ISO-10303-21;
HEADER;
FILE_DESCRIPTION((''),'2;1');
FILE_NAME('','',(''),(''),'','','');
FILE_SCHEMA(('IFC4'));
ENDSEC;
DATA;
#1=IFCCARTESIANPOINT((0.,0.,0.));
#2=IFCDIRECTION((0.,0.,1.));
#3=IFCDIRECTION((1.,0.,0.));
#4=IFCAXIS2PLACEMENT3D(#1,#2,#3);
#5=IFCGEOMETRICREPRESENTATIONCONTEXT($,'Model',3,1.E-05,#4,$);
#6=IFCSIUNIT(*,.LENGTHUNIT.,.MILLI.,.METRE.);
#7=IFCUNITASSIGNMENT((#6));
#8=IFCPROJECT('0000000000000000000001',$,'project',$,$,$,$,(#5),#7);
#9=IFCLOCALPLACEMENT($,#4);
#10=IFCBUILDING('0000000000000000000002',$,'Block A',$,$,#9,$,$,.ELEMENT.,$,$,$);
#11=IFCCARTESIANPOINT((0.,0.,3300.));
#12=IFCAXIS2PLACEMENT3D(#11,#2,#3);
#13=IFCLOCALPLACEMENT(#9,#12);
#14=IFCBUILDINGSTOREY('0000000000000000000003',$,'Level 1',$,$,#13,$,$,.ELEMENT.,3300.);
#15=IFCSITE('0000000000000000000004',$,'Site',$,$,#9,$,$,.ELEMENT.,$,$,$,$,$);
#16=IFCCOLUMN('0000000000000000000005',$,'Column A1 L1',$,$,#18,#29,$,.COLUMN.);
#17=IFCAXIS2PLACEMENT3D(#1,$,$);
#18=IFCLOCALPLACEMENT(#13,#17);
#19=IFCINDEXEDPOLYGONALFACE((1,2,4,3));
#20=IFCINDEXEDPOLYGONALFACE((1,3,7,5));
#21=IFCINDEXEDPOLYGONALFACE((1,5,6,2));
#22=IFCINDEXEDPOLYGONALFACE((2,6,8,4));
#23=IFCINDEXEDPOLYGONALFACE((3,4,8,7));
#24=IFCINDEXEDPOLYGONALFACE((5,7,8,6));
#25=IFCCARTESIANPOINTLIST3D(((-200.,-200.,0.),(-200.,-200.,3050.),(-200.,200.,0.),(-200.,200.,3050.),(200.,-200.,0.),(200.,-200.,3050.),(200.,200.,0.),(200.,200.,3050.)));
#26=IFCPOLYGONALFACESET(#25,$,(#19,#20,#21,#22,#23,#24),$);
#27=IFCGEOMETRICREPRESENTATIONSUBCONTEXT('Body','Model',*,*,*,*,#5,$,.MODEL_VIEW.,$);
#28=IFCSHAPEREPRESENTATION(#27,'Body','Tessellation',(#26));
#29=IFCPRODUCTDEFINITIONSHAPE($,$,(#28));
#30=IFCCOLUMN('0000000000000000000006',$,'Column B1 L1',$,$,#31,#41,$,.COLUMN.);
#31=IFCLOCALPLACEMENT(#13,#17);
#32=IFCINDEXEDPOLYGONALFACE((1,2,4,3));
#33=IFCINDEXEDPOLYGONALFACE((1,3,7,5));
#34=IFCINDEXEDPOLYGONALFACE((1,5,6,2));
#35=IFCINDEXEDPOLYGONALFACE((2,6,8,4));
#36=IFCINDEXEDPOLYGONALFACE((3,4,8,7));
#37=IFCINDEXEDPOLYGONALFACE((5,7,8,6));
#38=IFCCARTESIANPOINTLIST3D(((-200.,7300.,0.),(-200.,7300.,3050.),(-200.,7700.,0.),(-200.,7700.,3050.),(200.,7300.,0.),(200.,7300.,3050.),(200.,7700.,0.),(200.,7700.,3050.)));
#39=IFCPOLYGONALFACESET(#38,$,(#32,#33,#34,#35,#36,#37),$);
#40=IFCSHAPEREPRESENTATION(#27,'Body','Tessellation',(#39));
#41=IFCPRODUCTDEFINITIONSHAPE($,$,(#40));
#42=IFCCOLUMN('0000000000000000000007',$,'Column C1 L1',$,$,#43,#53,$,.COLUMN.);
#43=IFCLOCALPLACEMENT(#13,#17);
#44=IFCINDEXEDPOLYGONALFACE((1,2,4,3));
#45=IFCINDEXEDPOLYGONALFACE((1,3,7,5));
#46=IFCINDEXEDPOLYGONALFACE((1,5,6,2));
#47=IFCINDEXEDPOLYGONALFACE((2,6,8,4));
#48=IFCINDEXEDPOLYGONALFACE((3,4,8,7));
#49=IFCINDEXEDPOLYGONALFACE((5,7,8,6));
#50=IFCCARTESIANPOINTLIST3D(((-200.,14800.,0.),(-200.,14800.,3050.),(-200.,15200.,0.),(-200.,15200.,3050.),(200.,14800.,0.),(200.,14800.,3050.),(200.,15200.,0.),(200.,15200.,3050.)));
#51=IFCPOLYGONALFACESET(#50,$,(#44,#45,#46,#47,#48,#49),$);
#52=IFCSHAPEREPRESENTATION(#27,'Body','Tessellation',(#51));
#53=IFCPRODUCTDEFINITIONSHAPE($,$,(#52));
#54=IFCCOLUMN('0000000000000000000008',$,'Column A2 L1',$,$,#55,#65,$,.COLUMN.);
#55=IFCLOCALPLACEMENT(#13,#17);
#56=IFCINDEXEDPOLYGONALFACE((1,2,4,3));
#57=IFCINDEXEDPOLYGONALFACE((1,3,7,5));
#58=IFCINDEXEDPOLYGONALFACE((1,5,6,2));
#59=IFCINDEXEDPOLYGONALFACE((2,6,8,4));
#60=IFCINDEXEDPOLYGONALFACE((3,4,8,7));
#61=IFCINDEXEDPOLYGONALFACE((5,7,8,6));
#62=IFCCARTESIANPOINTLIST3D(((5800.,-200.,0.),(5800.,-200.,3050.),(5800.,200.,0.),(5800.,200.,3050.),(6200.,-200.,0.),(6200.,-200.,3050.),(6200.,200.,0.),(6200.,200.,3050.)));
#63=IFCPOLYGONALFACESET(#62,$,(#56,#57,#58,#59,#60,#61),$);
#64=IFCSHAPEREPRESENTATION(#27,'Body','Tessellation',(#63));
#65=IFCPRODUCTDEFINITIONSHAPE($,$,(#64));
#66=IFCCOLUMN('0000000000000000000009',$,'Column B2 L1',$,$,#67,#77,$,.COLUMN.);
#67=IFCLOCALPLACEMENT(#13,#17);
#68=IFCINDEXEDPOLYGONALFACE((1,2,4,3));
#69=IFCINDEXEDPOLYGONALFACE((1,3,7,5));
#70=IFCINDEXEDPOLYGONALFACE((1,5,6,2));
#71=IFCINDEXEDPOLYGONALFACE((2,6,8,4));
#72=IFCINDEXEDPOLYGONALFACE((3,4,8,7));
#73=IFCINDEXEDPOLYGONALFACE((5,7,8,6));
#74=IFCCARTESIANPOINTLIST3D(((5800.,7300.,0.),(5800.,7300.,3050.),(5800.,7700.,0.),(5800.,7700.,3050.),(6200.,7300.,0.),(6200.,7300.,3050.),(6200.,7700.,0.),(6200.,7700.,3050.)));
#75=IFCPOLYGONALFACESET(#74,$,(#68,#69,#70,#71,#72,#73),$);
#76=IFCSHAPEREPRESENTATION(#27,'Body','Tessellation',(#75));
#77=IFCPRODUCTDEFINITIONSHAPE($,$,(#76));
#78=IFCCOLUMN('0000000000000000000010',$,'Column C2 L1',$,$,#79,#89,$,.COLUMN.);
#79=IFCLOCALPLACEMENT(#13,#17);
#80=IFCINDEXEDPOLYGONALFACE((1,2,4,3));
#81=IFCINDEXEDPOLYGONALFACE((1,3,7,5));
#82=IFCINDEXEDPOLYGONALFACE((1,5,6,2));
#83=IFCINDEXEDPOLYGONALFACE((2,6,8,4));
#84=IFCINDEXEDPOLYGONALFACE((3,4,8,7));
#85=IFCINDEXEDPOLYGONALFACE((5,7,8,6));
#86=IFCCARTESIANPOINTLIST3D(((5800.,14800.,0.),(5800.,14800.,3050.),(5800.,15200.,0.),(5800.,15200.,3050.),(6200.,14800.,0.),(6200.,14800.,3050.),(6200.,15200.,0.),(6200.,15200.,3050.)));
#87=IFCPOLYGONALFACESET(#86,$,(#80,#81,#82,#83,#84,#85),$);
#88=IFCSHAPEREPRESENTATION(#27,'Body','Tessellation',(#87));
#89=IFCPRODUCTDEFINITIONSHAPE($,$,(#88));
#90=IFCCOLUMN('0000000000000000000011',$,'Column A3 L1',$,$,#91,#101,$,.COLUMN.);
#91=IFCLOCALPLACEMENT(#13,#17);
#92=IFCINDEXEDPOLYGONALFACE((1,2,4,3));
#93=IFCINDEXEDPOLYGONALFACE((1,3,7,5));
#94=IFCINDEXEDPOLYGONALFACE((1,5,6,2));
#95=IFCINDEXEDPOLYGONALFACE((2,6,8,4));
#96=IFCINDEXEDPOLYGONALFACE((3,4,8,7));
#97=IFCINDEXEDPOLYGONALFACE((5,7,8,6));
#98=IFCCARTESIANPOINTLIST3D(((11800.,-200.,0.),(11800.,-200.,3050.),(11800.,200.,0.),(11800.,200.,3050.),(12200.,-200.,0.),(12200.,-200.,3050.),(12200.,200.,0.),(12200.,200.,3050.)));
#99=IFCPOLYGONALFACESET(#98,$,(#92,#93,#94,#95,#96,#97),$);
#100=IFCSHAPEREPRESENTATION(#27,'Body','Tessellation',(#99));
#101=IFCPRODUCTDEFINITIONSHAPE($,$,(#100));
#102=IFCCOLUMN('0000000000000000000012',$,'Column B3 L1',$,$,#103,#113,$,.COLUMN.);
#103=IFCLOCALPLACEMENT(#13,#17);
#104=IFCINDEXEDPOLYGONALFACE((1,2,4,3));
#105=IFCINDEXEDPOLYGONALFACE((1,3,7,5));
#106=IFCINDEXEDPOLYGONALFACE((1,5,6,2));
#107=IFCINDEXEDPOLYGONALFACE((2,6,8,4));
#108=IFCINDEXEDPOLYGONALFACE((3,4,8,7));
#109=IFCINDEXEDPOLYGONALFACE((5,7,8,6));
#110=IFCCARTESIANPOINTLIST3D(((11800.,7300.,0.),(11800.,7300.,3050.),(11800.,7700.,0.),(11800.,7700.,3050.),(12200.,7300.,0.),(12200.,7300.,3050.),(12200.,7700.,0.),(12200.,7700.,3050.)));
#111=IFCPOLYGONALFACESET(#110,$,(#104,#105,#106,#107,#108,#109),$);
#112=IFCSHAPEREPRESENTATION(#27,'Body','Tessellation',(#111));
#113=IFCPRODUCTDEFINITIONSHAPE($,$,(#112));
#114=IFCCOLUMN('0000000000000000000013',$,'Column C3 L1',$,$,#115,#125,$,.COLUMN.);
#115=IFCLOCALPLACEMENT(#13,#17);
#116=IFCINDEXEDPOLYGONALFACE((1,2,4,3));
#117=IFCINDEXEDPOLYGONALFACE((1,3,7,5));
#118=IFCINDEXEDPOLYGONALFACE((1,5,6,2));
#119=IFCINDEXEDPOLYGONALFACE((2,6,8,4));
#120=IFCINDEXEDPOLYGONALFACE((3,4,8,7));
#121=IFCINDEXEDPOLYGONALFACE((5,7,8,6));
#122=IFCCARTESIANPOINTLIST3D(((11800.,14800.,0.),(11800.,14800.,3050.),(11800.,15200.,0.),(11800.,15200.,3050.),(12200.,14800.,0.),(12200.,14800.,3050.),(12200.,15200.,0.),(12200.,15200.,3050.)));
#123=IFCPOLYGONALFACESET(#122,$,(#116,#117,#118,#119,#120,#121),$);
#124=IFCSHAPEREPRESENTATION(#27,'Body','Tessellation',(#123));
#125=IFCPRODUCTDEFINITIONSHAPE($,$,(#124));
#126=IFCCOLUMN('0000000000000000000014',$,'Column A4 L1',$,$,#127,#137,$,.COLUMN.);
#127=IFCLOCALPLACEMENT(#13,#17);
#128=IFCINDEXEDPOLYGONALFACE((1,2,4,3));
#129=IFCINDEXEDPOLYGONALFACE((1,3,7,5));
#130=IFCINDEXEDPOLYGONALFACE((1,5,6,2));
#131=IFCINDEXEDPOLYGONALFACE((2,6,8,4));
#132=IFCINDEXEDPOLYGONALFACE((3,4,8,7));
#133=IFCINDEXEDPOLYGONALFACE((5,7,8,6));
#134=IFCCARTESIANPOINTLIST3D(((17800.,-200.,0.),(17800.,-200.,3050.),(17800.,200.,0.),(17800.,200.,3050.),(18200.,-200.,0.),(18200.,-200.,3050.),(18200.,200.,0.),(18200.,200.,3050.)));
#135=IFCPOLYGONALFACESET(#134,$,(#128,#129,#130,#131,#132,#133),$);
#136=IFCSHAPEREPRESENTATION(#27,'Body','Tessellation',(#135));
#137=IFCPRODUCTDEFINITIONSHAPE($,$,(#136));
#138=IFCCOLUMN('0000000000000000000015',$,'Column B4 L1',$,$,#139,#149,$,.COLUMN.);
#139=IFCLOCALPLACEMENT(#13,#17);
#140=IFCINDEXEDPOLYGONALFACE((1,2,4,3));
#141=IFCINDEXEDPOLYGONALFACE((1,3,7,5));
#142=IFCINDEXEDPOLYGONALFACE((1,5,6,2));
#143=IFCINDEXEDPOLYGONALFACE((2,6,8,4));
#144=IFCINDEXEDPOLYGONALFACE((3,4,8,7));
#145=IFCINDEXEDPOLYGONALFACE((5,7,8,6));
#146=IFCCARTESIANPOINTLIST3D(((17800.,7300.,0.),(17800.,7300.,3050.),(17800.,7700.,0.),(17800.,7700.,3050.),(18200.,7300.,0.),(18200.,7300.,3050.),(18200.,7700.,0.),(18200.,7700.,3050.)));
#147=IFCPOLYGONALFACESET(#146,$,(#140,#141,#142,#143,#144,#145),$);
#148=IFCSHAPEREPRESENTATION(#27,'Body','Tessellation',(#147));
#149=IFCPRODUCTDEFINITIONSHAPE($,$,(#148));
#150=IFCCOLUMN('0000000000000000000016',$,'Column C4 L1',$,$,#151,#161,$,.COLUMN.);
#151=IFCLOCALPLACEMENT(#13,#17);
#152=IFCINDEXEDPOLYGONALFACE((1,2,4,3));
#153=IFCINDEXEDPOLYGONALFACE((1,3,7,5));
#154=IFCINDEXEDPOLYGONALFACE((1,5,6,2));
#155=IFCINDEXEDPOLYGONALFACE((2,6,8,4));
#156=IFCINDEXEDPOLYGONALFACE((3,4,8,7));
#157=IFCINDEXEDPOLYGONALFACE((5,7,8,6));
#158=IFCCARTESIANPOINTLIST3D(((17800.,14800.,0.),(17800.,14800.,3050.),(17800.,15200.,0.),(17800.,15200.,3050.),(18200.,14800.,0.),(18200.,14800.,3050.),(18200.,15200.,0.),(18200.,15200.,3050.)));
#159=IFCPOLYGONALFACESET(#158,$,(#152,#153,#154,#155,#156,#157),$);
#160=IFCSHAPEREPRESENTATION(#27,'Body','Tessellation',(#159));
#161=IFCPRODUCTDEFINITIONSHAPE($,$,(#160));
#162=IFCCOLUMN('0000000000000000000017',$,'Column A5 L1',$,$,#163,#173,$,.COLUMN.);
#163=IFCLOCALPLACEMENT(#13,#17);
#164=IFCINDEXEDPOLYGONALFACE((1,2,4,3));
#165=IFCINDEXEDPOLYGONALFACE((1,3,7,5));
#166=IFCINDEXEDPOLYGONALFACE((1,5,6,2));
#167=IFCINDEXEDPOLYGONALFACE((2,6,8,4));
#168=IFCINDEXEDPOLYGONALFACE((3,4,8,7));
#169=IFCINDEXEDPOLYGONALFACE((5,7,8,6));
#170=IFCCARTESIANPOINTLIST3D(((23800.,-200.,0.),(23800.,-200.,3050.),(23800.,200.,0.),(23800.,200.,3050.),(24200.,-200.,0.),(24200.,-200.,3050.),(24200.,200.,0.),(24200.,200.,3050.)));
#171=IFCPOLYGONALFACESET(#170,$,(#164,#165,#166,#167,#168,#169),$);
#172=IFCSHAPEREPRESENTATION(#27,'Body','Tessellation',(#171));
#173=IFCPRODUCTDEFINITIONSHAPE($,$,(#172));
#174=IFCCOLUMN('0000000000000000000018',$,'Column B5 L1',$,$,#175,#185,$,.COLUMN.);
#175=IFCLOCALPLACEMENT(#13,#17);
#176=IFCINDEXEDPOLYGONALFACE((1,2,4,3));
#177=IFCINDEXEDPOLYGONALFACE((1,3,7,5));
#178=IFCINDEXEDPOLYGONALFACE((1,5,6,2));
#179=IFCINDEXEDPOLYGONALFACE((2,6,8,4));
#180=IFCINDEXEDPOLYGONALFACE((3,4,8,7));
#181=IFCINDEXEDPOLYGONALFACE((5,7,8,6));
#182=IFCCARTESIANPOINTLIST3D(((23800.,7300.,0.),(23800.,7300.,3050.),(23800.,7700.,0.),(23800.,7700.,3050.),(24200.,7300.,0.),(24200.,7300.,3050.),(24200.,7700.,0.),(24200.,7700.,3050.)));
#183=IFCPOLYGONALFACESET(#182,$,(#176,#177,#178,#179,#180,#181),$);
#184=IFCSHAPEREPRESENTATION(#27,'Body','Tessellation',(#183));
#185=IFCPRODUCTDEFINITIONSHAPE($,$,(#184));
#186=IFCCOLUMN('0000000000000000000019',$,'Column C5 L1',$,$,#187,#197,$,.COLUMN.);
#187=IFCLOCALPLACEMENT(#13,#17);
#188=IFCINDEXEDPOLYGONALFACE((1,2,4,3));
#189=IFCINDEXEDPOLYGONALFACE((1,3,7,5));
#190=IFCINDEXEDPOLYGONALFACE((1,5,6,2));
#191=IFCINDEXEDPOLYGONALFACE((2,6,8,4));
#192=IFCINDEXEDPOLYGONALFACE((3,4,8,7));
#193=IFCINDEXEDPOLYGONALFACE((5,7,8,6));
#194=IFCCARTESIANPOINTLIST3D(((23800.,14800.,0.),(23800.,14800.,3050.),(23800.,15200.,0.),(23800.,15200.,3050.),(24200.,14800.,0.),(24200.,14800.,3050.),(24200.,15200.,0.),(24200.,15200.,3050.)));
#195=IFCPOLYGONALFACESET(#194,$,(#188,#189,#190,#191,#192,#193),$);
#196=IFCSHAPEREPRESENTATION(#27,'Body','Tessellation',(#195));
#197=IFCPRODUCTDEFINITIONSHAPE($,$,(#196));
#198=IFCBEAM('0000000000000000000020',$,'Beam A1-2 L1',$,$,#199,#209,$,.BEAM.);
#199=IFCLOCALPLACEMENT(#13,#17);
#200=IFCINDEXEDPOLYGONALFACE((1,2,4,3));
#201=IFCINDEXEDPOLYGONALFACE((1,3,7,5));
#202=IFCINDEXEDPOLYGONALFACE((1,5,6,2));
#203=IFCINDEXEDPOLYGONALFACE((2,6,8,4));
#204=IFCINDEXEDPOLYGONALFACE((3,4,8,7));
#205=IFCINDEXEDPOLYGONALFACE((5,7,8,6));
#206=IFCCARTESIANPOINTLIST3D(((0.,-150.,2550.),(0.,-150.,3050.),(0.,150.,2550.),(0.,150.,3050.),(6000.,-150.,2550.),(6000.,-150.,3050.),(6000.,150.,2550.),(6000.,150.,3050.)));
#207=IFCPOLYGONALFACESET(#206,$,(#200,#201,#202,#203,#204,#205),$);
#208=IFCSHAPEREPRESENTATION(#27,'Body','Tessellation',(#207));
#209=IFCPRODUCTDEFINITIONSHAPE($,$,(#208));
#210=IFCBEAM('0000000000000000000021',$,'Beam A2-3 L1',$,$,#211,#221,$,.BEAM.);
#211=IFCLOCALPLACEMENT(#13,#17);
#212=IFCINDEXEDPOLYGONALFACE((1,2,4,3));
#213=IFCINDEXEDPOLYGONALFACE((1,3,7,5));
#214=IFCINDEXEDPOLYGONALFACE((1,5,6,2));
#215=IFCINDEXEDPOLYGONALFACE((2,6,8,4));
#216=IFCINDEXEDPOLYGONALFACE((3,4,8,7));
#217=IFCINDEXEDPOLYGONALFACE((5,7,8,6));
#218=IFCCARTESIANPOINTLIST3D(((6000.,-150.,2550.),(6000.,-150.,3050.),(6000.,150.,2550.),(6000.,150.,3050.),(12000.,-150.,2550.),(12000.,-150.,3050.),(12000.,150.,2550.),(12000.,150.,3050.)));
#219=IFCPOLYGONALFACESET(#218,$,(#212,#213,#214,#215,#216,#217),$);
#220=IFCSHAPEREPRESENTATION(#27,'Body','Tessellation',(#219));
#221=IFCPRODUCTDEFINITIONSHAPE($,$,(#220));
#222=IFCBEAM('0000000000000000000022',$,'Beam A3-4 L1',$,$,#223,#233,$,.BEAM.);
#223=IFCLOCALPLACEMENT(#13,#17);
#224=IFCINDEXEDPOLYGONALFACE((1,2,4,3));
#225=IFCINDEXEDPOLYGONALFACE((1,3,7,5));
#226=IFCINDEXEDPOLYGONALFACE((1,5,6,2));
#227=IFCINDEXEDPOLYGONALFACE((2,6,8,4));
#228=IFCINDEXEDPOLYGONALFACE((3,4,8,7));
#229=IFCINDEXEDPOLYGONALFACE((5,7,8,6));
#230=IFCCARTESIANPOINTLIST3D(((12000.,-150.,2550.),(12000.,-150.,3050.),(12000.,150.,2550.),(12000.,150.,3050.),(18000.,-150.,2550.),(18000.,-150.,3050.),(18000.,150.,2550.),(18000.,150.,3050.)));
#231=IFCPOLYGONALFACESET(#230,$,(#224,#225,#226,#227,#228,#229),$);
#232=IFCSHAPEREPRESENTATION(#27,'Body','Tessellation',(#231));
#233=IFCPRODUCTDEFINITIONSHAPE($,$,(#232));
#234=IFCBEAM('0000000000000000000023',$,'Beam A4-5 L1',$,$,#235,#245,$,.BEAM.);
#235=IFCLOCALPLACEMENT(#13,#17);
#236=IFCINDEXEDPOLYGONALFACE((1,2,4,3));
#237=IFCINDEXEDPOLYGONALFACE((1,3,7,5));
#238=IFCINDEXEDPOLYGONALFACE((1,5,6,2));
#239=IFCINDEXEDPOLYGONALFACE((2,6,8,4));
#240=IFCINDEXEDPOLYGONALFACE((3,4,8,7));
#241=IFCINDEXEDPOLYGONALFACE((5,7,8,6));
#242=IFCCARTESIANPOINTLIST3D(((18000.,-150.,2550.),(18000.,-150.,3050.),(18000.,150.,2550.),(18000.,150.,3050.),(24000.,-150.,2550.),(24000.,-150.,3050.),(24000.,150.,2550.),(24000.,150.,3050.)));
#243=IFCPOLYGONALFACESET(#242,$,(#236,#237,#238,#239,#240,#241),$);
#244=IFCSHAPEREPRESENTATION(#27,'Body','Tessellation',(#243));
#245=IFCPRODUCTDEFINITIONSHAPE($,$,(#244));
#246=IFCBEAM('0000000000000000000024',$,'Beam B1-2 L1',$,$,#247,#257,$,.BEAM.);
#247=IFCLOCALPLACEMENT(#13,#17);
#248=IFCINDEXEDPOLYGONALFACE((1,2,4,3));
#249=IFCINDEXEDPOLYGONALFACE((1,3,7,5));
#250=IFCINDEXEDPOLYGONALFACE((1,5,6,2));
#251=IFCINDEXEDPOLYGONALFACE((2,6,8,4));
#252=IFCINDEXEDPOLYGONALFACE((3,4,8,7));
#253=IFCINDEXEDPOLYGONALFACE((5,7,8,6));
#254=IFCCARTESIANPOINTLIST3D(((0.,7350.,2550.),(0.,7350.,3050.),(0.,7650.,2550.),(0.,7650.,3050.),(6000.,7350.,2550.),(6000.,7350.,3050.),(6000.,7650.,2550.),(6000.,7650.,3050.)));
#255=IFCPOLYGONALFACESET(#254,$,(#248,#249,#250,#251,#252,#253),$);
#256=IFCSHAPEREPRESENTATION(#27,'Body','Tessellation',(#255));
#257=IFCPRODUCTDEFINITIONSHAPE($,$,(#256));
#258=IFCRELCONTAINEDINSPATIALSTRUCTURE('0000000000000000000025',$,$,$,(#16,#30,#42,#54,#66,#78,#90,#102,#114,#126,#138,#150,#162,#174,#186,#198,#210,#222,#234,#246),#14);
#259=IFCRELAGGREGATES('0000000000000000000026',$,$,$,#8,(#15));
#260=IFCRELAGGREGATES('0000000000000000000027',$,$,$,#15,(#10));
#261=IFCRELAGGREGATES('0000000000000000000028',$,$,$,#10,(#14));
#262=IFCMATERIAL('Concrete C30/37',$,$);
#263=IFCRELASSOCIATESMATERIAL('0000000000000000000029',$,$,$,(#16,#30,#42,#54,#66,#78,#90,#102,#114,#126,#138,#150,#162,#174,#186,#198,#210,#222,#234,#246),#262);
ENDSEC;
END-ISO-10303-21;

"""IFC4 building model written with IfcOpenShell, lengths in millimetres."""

from ifc_helpers import new_model, si_unit, frame, frame_2d, origin_with_axes, origin_2d, place, context, subcontext, project, spatial, rectangle, extrude, material, element, save


model = new_model("IFC4")

# Units and contexts
model_context = context("Model", 3, precision=1e-05, world=origin_with_axes())
body_context = subcontext(model_context, "Body", "Model", "MODEL_VIEW")
ifc_project = project(units=[si_unit("LENGTHUNIT", "METRE", prefix="MILLI")], contexts=[model_context])

# Site, building, storey
placement = place(None, origin_with_axes())
site = spatial("IfcSite", under=ifc_project, at=placement, Name="Site", CompositionType="ELEMENT")
building = spatial("IfcBuilding", under=site, at=placement, Name="Block A", CompositionType="ELEMENT")
storey_placement = place(placement, frame((0.0, 0.0, 3300.0), z_axis=(0.0, 0.0, 1.0), x_axis=(1.0, 0.0, 0.0)))
storey = spatial("IfcBuildingStorey", under=building, at=storey_placement, Name="Level 1", CompositionType="ELEMENT", Elevation=3300.0)

# Columns
ifc_material_1 = material(Name="Concrete C30/37")
for number, where, z_axis, x_axis, name in (
    (1, (0.0, 0.0, 3300.0), (0.0, 0.0, 1.0), (1.0, 0.0, 0.0), "Column A1 L1"),
    (2, (0.0, 7500.0, 3300.0), (0.0, 0.0, 1.0), (1.0, 0.0, 0.0), "Column B1 L1"),
    (3, (0.0, 15000.0, 3300.0), (0.0, 0.0, 1.0), (1.0, 0.0, 0.0), "Column C1 L1"),
    (4, (6000.0, 0.0, 3300.0), (0.0, 0.0, 1.0), (1.0, 0.0, 0.0), "Column A2 L1"),
    (5, (6000.0, 7500.0, 3300.0), (0.0, 0.0, 1.0), (1.0, 0.0, 0.0), "Column B2 L1"),
    (6, (6000.0, 15000.0, 3300.0), (0.0, 0.0, 1.0), (1.0, 0.0, 0.0), "Column C2 L1"),
    (7, (12000.0, 0.0, 3300.0), (0.0, 0.0, 1.0), (1.0, 0.0, 0.0), "Column A3 L1"),
    (8, (12000.0, 7500.0, 3300.0), (0.0, 0.0, 1.0), (1.0, 0.0, 0.0), "Column B3 L1"),
    (9, (12000.0, 15000.0, 3300.0), (0.0, 0.0, 1.0), (1.0, 0.0, 0.0), "Column C3 L1"),
    (10, (18000.0, 0.0, 3300.0), (0.0, 0.0, 1.0), (1.0, 0.0, 0.0), "Column A4 L1"),
    (11, (18000.0, 7500.0, 3300.0), (0.0, 0.0, 1.0), (1.0, 0.0, 0.0), "Column B4 L1"),
    (12, (18000.0, 15000.0, 3300.0), (0.0, 0.0, 1.0), (1.0, 0.0, 0.0), "Column C4 L1"),
    (13, (24000.0, 0.0, 3300.0), (0.0, 0.0, 1.0), (1.0, 0.0, 0.0), "Column A5 L1"),
    (14, (24000.0, 7500.0, 3300.0), (0.0, 0.0, 1.0), (1.0, 0.0, 0.0), "Column B5 L1"),
    (15, (24000.0, 15000.0, 3300.0), (0.0, 0.0, 1.0), (1.0, 0.0, 0.0), "Column C5 L1"),
):
    element("IfcColumn", number, at=place(placement, frame(where, z_axis=z_axis, x_axis=x_axis)), inside=storey, material=ifc_material_1, Name=name, PredefinedType="COLUMN", context=body_context, shape_type="SweptSolid", body=[
        extrude(rectangle(XDim=400.0, YDim=400.0, at=origin_2d()), origin_with_axes(), (0.0, 0.0, 1.0), 3050.0),
    ])

# Beams
for number, where, z_axis, x_axis, name in (
    (16, (0.0, 0.0, 5850.0), (0.0, 0.0, 1.0), (1.0, 0.0, 0.0), "Beam A1-2 L1"),
    (17, (6000.0, 0.0, 5850.0), (0.0, 0.0, 1.0), (1.0, 0.0, 0.0), "Beam A2-3 L1"),
    (18, (12000.0, 0.0, 5850.0), (0.0, 0.0, 1.0), (1.0, 0.0, 0.0), "Beam A3-4 L1"),
    (19, (18000.0, 0.0, 5850.0), (0.0, 0.0, 1.0), (1.0, 0.0, 0.0), "Beam A4-5 L1"),
    (20, (0.0, 7500.0, 5850.0), (0.0, 0.0, 1.0), (1.0, 0.0, 0.0), "Beam B1-2 L1"),
):
    element("IfcBeam", number, at=place(placement, frame(where, z_axis=z_axis, x_axis=x_axis)), inside=storey, material=ifc_material_1, Name=name, PredefinedType="BEAM", context=body_context, shape_type="SweptSolid", body=[
        extrude(rectangle(XDim=6000.0, YDim=300.0, at=frame_2d((3000.0, 0.0))), origin_with_axes(), (0.0, 0.0, 1.0), 500.0),
    ])

save(model, "model.ifc")
